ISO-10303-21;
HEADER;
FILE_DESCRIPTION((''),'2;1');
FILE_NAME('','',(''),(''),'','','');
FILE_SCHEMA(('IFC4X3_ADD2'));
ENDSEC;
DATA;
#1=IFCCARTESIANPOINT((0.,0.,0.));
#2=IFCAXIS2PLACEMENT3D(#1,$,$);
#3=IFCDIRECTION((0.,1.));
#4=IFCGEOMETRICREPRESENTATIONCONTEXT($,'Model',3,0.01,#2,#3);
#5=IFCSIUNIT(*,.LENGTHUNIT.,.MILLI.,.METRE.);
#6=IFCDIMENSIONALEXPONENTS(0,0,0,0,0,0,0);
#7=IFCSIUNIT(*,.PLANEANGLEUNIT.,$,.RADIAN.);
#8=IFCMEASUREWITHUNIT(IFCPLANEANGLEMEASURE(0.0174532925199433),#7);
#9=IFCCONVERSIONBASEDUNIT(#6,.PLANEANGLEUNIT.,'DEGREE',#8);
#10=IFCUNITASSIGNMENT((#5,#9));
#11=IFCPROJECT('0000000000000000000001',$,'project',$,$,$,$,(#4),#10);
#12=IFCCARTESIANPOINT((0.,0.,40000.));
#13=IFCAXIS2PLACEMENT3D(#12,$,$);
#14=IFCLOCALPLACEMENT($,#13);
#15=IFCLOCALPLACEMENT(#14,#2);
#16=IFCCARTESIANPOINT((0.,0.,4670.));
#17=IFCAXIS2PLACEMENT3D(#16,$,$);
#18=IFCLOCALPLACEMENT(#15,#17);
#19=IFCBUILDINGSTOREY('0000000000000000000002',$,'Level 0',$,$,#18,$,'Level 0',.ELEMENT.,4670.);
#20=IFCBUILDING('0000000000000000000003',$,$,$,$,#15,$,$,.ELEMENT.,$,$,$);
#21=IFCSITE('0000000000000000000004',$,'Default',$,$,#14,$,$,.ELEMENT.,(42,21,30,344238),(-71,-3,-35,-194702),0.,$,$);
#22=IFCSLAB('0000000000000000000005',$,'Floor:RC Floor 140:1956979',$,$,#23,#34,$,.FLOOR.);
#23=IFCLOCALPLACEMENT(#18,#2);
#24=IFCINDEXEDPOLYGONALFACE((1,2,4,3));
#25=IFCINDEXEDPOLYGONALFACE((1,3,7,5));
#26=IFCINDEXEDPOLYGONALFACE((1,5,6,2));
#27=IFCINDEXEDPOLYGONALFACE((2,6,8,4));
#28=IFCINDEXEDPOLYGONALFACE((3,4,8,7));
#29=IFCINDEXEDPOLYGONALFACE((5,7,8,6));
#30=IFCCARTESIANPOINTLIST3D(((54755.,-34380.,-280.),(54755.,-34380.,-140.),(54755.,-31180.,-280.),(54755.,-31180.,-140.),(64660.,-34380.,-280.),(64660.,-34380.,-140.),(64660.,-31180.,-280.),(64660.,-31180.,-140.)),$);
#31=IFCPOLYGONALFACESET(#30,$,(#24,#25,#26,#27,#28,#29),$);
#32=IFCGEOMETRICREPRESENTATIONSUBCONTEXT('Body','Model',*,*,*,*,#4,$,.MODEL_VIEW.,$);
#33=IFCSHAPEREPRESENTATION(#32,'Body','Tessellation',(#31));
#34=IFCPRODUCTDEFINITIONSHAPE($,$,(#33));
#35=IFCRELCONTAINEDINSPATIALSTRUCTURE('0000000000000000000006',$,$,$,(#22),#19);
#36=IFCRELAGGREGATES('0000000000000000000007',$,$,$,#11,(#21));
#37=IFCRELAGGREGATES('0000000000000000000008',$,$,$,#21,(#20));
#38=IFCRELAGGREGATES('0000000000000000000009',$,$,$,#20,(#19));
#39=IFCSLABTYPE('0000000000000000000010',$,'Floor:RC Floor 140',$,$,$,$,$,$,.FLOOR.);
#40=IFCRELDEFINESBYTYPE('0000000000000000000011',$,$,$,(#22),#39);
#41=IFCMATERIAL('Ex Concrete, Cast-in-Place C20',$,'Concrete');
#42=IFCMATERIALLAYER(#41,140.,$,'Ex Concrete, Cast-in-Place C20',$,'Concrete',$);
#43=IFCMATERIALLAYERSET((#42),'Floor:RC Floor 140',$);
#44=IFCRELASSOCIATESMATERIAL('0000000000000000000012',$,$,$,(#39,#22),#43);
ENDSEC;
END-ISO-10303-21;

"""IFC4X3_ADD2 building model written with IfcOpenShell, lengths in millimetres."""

from ifc_helpers import new_model, entity, si_unit, converted_unit, direction, frame, frame_2d, origin, place, context, subcontext, project, spatial, rectangle, extrude, material, layer, layer_set, layer_usage, type_object, element, save


model = new_model("IFC4X3_ADD2")

# Units and contexts
model_context = context("Model", 3, precision=0.01, world=origin(), true_north=direction((0.0, 1.0)))
body_context = subcontext(model_context, "Body", "Model", "MODEL_VIEW")
ifc_project = project(units=[si_unit("LENGTHUNIT", "METRE", prefix="MILLI"), converted_unit("PLANEANGLEUNIT", "DEGREE", entity("IfcPlaneAngleMeasure", 0.0174532925199433), si_unit("PLANEANGLEUNIT", "RADIAN"), dimensions=[0, 0, 0, 0, 0, 0, 0])], contexts=[model_context])

# Site, building, storey
site_placement = place(None, frame((0.0, 0.0, 40000.0)))
site = spatial("IfcSite", under=ifc_project, at=site_placement, Name="Default", CompositionType="ELEMENT", RefLatitude=(42, 21, 30, 344238), RefLongitude=(-71, -3, -35, -194702), RefElevation=0.0)
building_placement = place(site_placement, origin())
building = spatial("IfcBuilding", under=site, at=building_placement, CompositionType="ELEMENT")
storey_placement = place(building_placement, frame((0.0, 0.0, 4670.0)))
storey = spatial("IfcBuildingStorey", under=building, at=storey_placement, Name="Level 0", LongName="Level 0", CompositionType="ELEMENT", Elevation=4670.0)

# Slab
ifc_material_1 = material(Name="Ex Concrete, Cast-in-Place C20", Category="Concrete")
ifc_layer_1 = layer(ifc_material_1, 140.0, Name="Ex Concrete, Cast-in-Place C20", Category="Concrete")
ifc_layer_set_1 = layer_set([ifc_layer_1], Name="Floor:RC Floor 140")
slab_type_1 = type_object("IfcSlabType", Name="Floor:RC Floor 140", PredefinedType="FLOOR", material=ifc_layer_set_1)
ifc_layer_usage_1 = layer_usage(ifc_layer_set_1, "AXIS3", "POSITIVE", 0.0)
slab_1_placement = place(storey_placement, origin())
element("IfcSlab", 1, at=slab_1_placement, inside=storey, type_object=slab_type_1, material=ifc_layer_usage_1, Name="Floor:RC Floor 140:1956979", PredefinedType="FLOOR", context=body_context, shape_type="SweptSolid", body=[
    extrude(rectangle(XDim=3200.0, YDim=9905.0, at=frame_2d((0.0, 0.0), x_axis=(1.0, 0.0))), frame((59707.5, -32780.0, -140.0), z_axis=(0.0, 0.0, -1.0), x_axis=(0.0, 1.0, 0.0)), (0.0, 0.0, 1.0), 140.0),
])

save(model, "model.ifc")
